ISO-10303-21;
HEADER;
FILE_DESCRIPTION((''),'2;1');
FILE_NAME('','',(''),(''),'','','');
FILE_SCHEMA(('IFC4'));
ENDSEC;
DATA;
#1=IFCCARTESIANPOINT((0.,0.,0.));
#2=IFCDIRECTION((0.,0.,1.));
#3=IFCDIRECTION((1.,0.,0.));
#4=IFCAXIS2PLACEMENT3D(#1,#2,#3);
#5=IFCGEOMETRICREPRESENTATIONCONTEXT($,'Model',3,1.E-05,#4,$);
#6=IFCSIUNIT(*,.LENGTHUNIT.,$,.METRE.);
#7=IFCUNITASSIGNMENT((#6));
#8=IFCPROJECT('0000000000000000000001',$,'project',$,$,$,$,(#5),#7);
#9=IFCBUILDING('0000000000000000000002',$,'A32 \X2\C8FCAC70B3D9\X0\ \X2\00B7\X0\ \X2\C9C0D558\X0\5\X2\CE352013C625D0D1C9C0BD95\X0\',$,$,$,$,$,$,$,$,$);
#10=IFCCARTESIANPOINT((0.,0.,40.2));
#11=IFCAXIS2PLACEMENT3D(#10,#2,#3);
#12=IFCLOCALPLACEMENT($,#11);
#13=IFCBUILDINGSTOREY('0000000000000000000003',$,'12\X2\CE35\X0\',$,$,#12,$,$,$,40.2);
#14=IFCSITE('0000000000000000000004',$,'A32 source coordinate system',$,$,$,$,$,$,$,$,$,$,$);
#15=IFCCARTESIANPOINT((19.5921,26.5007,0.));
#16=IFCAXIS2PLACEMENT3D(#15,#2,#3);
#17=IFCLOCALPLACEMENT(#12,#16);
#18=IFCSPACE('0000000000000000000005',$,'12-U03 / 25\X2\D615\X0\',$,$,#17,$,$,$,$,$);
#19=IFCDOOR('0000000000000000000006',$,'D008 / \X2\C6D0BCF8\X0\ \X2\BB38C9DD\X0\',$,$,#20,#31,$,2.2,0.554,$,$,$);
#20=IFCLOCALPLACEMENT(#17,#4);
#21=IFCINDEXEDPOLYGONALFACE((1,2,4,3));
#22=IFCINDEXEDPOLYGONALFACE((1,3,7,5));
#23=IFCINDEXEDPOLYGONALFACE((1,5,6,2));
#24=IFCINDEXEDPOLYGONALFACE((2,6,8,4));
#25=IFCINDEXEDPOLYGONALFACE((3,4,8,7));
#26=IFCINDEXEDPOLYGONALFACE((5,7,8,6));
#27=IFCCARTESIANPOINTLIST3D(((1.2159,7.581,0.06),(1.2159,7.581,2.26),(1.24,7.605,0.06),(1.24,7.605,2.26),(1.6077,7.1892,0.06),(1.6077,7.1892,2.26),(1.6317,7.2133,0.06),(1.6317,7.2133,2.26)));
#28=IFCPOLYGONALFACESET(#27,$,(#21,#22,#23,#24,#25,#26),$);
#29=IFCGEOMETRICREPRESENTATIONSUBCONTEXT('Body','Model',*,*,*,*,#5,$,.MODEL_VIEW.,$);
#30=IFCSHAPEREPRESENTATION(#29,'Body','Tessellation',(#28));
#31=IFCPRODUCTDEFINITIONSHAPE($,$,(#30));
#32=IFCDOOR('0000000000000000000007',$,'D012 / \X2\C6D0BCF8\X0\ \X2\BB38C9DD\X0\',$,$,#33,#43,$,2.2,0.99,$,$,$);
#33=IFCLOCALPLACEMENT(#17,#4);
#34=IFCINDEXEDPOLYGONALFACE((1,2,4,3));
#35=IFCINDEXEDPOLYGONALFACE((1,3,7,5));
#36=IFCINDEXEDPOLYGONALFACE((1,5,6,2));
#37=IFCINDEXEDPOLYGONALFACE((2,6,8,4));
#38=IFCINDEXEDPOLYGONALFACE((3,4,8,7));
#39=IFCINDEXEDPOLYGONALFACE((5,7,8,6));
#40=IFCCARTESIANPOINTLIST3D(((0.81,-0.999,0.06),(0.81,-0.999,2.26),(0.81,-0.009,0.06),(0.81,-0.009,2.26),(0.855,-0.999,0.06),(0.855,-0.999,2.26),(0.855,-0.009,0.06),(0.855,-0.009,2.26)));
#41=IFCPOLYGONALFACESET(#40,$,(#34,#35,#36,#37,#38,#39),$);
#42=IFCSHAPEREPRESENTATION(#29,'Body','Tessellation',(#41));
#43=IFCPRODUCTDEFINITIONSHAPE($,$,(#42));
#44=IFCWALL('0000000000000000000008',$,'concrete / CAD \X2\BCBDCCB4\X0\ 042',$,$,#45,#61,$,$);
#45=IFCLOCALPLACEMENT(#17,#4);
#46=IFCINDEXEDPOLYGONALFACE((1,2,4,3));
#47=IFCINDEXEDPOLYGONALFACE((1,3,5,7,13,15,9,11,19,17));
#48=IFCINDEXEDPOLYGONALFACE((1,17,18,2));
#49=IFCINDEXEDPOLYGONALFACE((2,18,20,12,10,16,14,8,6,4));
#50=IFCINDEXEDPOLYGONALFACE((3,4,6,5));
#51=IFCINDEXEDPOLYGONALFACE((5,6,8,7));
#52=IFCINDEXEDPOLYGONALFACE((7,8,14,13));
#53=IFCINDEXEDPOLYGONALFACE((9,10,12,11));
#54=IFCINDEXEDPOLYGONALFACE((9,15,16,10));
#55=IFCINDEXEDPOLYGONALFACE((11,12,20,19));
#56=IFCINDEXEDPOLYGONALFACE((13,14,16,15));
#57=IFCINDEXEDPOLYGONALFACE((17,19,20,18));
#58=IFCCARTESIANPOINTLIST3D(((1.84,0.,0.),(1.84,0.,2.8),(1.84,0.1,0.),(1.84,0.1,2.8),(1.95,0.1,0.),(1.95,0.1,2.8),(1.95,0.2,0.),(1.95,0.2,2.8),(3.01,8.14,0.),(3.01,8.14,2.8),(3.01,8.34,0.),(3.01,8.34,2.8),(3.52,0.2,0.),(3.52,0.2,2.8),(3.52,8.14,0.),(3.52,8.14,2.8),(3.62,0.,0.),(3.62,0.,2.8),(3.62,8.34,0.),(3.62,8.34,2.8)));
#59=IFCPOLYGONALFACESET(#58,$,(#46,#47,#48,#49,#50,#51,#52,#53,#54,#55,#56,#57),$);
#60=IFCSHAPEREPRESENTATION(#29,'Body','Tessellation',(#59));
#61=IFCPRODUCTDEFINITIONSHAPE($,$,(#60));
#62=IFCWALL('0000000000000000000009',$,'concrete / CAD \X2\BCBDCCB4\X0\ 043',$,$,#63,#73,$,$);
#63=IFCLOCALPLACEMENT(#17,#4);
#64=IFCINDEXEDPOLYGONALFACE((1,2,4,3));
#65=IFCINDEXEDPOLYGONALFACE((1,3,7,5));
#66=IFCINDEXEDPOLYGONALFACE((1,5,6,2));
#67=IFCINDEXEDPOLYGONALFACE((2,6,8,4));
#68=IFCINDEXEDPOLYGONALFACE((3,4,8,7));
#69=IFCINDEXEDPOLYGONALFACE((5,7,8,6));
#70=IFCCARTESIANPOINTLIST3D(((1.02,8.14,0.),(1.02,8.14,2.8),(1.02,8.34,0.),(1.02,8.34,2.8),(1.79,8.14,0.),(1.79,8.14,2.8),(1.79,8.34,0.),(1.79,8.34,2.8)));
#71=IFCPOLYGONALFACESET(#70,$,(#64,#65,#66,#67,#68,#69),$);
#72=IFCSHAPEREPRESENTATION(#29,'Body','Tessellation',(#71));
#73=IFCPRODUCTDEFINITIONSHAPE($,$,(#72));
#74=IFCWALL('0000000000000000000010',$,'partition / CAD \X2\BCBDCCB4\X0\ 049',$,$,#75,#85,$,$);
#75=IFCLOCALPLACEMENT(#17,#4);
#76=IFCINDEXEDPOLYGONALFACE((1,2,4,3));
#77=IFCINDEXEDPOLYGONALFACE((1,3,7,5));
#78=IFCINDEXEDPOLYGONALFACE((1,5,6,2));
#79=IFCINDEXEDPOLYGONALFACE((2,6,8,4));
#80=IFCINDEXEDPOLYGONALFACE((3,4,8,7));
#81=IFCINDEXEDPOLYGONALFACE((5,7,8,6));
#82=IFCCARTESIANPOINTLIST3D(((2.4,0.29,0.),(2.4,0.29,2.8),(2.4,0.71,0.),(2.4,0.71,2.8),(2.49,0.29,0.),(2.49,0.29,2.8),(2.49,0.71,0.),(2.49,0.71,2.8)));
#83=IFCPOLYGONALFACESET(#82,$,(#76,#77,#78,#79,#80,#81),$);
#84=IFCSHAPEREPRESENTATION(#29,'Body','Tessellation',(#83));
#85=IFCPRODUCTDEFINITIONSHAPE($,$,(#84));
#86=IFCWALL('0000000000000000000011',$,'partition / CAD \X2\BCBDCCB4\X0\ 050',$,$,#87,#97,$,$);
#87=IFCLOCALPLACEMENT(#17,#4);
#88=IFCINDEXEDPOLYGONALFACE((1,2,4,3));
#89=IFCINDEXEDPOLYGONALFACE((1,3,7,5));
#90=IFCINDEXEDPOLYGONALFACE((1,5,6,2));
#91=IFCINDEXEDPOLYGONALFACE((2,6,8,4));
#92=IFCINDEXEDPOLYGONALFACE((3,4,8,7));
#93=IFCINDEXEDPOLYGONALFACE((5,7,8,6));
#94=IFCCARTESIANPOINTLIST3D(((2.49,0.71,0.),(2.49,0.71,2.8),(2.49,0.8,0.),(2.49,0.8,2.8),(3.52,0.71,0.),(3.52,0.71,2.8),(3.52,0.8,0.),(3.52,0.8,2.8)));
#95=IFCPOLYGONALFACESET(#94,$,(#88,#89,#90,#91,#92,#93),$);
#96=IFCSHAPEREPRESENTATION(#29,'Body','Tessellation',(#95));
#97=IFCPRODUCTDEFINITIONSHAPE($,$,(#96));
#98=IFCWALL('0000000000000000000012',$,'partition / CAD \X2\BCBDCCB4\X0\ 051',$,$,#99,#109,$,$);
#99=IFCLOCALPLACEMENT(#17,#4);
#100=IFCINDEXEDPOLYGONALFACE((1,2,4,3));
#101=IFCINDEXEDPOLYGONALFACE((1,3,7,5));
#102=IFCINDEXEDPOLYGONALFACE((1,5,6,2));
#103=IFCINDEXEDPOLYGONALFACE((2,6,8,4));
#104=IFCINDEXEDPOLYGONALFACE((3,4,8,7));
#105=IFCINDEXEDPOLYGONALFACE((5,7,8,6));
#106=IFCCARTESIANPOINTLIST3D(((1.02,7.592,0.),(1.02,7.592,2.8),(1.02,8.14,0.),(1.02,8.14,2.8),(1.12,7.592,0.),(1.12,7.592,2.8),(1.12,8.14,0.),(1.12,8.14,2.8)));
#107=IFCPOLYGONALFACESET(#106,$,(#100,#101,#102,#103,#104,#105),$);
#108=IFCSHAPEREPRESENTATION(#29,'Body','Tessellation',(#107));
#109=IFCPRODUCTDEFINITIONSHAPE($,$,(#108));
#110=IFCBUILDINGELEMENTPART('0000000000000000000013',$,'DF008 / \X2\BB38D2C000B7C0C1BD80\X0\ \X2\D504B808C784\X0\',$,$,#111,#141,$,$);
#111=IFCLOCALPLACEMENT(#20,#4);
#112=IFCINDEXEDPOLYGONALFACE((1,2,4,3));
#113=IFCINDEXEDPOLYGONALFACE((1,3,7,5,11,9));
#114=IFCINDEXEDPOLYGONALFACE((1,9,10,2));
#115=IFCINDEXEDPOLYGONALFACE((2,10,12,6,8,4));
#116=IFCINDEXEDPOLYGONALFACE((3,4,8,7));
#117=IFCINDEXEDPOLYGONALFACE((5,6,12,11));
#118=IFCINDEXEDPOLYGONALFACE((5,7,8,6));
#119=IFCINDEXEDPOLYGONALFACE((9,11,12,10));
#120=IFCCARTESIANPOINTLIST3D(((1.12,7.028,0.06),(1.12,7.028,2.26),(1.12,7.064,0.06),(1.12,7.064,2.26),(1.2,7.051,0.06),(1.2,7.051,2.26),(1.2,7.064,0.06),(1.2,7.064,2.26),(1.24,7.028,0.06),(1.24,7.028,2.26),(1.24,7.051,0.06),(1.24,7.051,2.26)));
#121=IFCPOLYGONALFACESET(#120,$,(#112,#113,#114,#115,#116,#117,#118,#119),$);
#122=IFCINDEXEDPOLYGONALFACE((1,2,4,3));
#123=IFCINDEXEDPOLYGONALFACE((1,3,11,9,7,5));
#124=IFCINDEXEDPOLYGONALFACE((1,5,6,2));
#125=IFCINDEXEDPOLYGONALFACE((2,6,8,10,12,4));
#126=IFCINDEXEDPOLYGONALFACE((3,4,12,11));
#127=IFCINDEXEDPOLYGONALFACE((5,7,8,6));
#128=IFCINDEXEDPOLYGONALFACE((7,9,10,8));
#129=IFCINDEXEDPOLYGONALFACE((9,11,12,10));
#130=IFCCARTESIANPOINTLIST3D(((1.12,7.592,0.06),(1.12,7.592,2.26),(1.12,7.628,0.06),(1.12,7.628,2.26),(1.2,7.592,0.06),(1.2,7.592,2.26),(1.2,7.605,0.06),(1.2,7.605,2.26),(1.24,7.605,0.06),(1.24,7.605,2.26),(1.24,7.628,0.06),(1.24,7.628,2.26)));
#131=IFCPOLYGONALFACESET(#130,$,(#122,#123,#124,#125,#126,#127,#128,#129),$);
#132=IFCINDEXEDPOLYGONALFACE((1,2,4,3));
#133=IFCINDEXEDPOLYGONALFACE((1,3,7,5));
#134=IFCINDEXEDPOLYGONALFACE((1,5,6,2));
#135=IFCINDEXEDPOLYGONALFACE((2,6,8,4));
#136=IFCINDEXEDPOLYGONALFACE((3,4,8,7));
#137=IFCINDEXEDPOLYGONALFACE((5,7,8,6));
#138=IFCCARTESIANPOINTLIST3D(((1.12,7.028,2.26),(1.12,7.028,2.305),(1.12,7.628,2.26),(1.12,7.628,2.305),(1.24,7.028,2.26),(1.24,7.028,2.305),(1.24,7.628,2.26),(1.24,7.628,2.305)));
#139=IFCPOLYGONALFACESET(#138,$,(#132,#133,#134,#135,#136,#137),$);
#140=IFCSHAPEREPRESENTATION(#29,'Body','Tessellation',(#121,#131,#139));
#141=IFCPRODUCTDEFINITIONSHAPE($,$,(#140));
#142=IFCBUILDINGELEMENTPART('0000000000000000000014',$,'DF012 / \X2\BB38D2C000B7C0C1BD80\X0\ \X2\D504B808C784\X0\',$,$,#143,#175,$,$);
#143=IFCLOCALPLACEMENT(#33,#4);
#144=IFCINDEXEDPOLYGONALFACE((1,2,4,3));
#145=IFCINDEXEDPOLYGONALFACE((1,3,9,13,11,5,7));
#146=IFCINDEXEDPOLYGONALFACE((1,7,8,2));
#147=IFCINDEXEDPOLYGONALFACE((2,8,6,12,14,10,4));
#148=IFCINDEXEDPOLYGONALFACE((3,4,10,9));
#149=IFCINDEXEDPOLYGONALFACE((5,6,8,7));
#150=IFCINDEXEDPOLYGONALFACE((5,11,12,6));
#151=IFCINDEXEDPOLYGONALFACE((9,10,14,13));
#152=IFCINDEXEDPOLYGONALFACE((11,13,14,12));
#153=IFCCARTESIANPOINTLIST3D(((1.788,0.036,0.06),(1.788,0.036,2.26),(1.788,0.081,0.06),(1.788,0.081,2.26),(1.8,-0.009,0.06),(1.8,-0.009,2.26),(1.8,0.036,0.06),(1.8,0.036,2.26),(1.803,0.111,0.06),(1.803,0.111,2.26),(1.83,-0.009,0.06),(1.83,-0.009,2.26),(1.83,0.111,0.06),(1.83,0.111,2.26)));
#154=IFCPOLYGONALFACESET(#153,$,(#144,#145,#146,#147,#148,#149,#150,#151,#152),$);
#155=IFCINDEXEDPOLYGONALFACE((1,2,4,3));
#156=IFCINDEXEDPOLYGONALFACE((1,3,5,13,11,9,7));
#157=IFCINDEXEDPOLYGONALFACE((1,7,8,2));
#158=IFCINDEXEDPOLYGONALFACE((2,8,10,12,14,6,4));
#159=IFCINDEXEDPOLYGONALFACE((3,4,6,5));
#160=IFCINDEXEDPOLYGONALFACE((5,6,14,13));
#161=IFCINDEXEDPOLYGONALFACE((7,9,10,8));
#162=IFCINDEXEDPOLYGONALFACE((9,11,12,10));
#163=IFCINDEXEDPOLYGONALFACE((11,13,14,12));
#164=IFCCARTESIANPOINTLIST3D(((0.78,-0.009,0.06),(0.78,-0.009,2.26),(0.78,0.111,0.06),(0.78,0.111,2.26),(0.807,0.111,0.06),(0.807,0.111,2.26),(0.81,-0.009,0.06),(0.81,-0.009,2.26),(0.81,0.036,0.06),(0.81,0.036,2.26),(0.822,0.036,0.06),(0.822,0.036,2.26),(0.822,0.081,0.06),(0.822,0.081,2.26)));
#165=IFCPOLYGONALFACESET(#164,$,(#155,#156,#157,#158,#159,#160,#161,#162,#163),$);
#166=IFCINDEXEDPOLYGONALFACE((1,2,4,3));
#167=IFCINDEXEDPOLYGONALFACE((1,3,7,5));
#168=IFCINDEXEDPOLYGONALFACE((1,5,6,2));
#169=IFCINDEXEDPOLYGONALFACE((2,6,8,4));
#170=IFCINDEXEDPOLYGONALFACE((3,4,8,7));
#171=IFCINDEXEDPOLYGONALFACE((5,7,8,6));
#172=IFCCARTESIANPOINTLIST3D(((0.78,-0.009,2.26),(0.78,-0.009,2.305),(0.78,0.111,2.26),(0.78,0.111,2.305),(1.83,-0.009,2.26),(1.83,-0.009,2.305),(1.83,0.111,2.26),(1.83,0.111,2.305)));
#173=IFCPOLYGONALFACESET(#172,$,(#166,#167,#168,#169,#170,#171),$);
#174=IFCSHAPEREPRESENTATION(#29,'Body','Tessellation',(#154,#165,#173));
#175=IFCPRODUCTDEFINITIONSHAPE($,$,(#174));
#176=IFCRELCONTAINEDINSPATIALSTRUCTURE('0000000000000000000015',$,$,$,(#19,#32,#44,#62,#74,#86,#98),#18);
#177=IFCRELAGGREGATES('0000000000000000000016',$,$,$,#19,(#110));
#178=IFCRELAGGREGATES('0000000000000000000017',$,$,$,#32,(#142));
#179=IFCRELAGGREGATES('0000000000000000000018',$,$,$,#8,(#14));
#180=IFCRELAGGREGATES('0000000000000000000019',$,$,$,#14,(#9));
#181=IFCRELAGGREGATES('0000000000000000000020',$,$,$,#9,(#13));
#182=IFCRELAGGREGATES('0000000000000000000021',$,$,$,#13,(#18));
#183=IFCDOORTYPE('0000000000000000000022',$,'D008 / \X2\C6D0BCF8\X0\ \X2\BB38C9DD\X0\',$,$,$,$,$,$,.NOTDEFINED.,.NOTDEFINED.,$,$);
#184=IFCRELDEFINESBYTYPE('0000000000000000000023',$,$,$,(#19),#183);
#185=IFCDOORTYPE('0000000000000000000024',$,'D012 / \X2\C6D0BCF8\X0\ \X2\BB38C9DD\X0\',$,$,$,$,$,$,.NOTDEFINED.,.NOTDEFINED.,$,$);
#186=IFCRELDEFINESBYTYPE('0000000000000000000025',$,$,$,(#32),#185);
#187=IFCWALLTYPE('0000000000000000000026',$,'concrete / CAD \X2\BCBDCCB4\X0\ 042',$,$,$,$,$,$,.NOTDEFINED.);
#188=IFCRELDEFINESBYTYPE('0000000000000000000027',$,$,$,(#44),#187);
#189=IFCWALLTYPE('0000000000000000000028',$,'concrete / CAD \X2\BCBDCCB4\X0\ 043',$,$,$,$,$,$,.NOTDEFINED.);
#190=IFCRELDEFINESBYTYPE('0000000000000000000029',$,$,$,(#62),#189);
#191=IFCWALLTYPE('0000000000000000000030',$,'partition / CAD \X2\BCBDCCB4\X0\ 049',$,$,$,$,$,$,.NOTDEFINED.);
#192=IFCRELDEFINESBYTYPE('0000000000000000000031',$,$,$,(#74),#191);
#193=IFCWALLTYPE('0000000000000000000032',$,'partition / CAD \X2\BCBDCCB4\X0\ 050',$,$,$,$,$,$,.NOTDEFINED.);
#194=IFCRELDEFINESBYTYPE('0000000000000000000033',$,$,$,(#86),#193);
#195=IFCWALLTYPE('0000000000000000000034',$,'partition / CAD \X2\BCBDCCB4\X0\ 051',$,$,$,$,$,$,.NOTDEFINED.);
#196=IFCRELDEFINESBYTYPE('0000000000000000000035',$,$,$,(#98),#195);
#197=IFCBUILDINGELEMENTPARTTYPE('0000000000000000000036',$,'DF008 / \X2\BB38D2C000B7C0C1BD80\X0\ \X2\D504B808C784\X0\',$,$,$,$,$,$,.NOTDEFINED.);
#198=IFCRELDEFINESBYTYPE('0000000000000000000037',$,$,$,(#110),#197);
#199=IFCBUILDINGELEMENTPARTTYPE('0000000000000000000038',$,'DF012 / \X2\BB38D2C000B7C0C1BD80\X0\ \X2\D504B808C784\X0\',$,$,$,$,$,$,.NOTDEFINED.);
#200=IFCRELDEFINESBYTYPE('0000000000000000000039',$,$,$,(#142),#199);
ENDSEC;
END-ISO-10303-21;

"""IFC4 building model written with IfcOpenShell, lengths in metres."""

from ifc_helpers import new_model, si_unit, frame, origin, origin_with_axes, place, context, subcontext, project, spatial, polyline, outline, extrude, source, transform, mapped, type_object, type_shapes, element, aggregate, save


model = new_model("IFC4")

# Units and contexts
model_context = context("Model", 3, precision=1e-05, world=origin_with_axes())
body_context = subcontext(model_context, "Body", "Model", "MODEL_VIEW")
ifc_project = project(units=[si_unit("LENGTHUNIT", "METRE")], contexts=[model_context])

# Site, building, storey, space
storey_placement = place(None, frame((0.0, 0.0, 40.2), z_axis=(0.0, 0.0, 1.0), x_axis=(1.0, 0.0, 0.0)))
space_placement = place(storey_placement, frame((19.5921, 26.5007, 0.0), z_axis=(0.0, 0.0, 1.0), x_axis=(1.0, 0.0, 0.0)))
site = spatial("IfcSite", under=ifc_project, Name="A32 source coordinate system")
building = spatial("IfcBuilding", under=site, Name="A32 주거동 · 지하5층–옥탑지붕")
storey = spatial("IfcBuildingStorey", under=building, at=storey_placement, Name="12층", Elevation=40.2)
space = spatial("IfcSpace", under=storey, at=space_placement, Name="12-U03 / 25형")

# Doors
door_type_1 = type_object("IfcDoorType", Name="D008 / 원본 문짝", OperationType="NOTDEFINED", PredefinedType="NOTDEFINED")
shared_shape_1 = source(origin(), body_context, "Body", "SweptSolid", [
    extrude(outline(polyline([(1.24, 7.605), (1.6317, 7.2133), (1.6077, 7.1892), (1.2159, 7.581), (1.24, 7.605)])), frame((0.0, 0.0, 0.06)), (0.0, 0.0, 1.0), 2.2),
])
type_shapes(door_type_1, [shared_shape_1])
door_1_placement = place(space_placement, origin_with_axes())
door_1 = element("IfcDoor", 1, at=door_1_placement, inside=space, type_object=door_type_1, Name="D008 / 원본 문짝", OverallHeight=2.2, OverallWidth=0.554, context=body_context, shape_type="MappedRepresentation", body=[
    mapped(shared_shape_1, transform((0.0, 0.0, 0.0), scale=1.0)),
])
door_type_2 = type_object("IfcDoorType", Name="D012 / 원본 문짝", OperationType="NOTDEFINED", PredefinedType="NOTDEFINED")
shared_shape_2 = source(origin(), body_context, "Body", "SweptSolid", [
    extrude(outline(polyline([(0.855, -0.999), (0.81, -0.999), (0.81, -0.009), (0.855, -0.009), (0.855, -0.999)])), frame((0.0, 0.0, 0.06)), (0.0, 0.0, 1.0), 2.2),
])
type_shapes(door_type_2, [shared_shape_2])
door_2_placement = place(space_placement, origin_with_axes())
door_2 = element("IfcDoor", 2, at=door_2_placement, inside=space, type_object=door_type_2, Name="D012 / 원본 문짝", OverallHeight=2.2, OverallWidth=0.99, context=body_context, shape_type="MappedRepresentation", body=[
    mapped(shared_shape_2, transform((0.0, 0.0, 0.0), scale=1.0)),
])

# Walls
wall_type_1 = type_object("IfcWallType", Name="concrete / CAD 벽체 042", PredefinedType="NOTDEFINED")
shared_shape_3 = source(origin(), body_context, "Body", "SweptSolid", [
    extrude(outline(polyline([(3.01, 8.34), (3.97, 8.34), (3.97, 8.34), (3.62, 8.34), (3.62, 0.0), (1.84, 0.0), (1.84, 0.1), (1.95, 0.1), (1.95, 0.2), (3.52, 0.2), (3.52, 8.14), (3.01, 8.14), (3.01, 8.34)])), origin(), (0.0, 0.0, 1.0), 2.8),
])
type_shapes(wall_type_1, [shared_shape_3])
wall_1_placement = place(space_placement, origin_with_axes())
element("IfcWall", 3, at=wall_1_placement, inside=space, type_object=wall_type_1, Name="concrete / CAD 벽체 042", context=body_context, shape_type="MappedRepresentation", body=[
    mapped(shared_shape_3, transform((0.0, 0.0, 0.0), scale=1.0)),
])
wall_type_2 = type_object("IfcWallType", Name="concrete / CAD 벽체 043", PredefinedType="NOTDEFINED")
shared_shape_4 = source(origin(), body_context, "Body", "SweptSolid", [
    extrude(outline(polyline([(1.79, 8.14), (1.02, 8.14), (1.02, 8.34), (1.79, 8.34), (1.79, 8.14)])), origin(), (0.0, 0.0, 1.0), 2.8),
])
type_shapes(wall_type_2, [shared_shape_4])
wall_2_placement = place(space_placement, origin_with_axes())
element("IfcWall", 4, at=wall_2_placement, inside=space, type_object=wall_type_2, Name="concrete / CAD 벽체 043", context=body_context, shape_type="MappedRepresentation", body=[
    mapped(shared_shape_4, transform((0.0, 0.0, 0.0), scale=1.0)),
])
wall_type_3 = type_object("IfcWallType", Name="partition / CAD 벽체 049", PredefinedType="NOTDEFINED")
shared_shape_5 = source(origin(), body_context, "Body", "SweptSolid", [
    extrude(outline(polyline([(2.49, 0.29), (2.4, 0.29), (2.4, 0.71), (2.49, 0.71), (2.49, 0.29)])), origin(), (0.0, 0.0, 1.0), 2.8),
])
type_shapes(wall_type_3, [shared_shape_5])
wall_3_placement = place(space_placement, origin_with_axes())
element("IfcWall", 5, at=wall_3_placement, inside=space, type_object=wall_type_3, Name="partition / CAD 벽체 049", context=body_context, shape_type="MappedRepresentation", body=[
    mapped(shared_shape_5, transform((0.0, 0.0, 0.0), scale=1.0)),
])
wall_type_4 = type_object("IfcWallType", Name="partition / CAD 벽체 050", PredefinedType="NOTDEFINED")
shared_shape_6 = source(origin(), body_context, "Body", "SweptSolid", [
    extrude(outline(polyline([(2.49, 0.71), (2.49, 0.8), (3.52, 0.8), (3.52, 0.71), (2.49, 0.71)])), origin(), (0.0, 0.0, 1.0), 2.8),
])
type_shapes(wall_type_4, [shared_shape_6])
wall_4_placement = place(space_placement, origin_with_axes())
element("IfcWall", 6, at=wall_4_placement, inside=space, type_object=wall_type_4, Name="partition / CAD 벽체 050", context=body_context, shape_type="MappedRepresentation", body=[
    mapped(shared_shape_6, transform((0.0, 0.0, 0.0), scale=1.0)),
])
wall_type_5 = type_object("IfcWallType", Name="partition / CAD 벽체 051", PredefinedType="NOTDEFINED")
shared_shape_7 = source(origin(), body_context, "Body", "SweptSolid", [
    extrude(outline(polyline([(1.02, 8.14), (1.12, 8.14), (1.12, 7.592), (1.02, 7.592), (1.02, 8.14)])), origin(), (0.0, 0.0, 1.0), 2.8),
])
type_shapes(wall_type_5, [shared_shape_7])
wall_5_placement = place(space_placement, origin_with_axes())
element("IfcWall", 7, at=wall_5_placement, inside=space, type_object=wall_type_5, Name="partition / CAD 벽체 051", context=body_context, shape_type="MappedRepresentation", body=[
    mapped(shared_shape_7, transform((0.0, 0.0, 0.0), scale=1.0)),
])

# Building element parts
building_element_part_type_1 = type_object("IfcBuildingElementPartType", Name="DF008 / 문틀·상부 프레임", PredefinedType="NOTDEFINED")
shared_shape_8 = source(origin(), body_context, "Body", "SweptSolid", [
    extrude(outline(polyline([(1.12, 7.064), (1.2, 7.064), (1.2, 7.051), (1.24, 7.051), (1.24, 7.028), (1.12, 7.028), (1.12, 7.064)])), frame((0.0, 0.0, 0.06)), (0.0, 0.0, 1.0), 2.2),
    extrude(outline(polyline([(1.24, 7.628), (1.24, 7.605), (1.2, 7.605), (1.2, 7.592), (1.12, 7.592), (1.12, 7.628), (1.24, 7.628)])), frame((0.0, 0.0, 0.06)), (0.0, 0.0, 1.0), 2.2),
    extrude(outline(polyline([(1.12, 7.028), (1.12, 7.628), (1.24, 7.628), (1.24, 7.028), (1.12, 7.028)])), frame((0.0, 0.0, 2.26)), (0.0, 0.0, 1.0), 0.045),
])
type_shapes(building_element_part_type_1, [shared_shape_8])
building_element_part_1_placement = place(door_1_placement, origin_with_axes())
building_element_part_1 = element("IfcBuildingElementPart", 8, at=building_element_part_1_placement, type_object=building_element_part_type_1, Name="DF008 / 문틀·상부 프레임", context=body_context, shape_type="MappedRepresentation", body=[
    mapped(shared_shape_8, transform((0.0, 0.0, 0.0), scale=1.0)),
])
aggregate(door_1, [building_element_part_1])
building_element_part_type_2 = type_object("IfcBuildingElementPartType", Name="DF012 / 문틀·상부 프레임", PredefinedType="NOTDEFINED")
shared_shape_9 = source(origin(), body_context, "Body", "SweptSolid", [
    extrude(outline(polyline([(1.8, -0.009), (1.8, 0.036), (1.788, 0.036), (1.788, 0.081), (1.803, 0.111), (1.83, 0.111), (1.83, -0.009), (1.8, -0.009)])), frame((0.0, 0.0, 0.06)), (0.0, 0.0, 1.0), 2.2),
    extrude(outline(polyline([(0.78, 0.111), (0.807, 0.111), (0.822, 0.081), (0.822, 0.036), (0.81, 0.036), (0.81, -0.009), (0.78, -0.009), (0.78, 0.111)])), frame((0.0, 0.0, 0.06)), (0.0, 0.0, 1.0), 2.2),
    extrude(outline(polyline([(0.78, -0.009), (0.78, 0.111), (1.83, 0.111), (1.83, -0.009), (0.78, -0.009)])), frame((0.0, 0.0, 2.26)), (0.0, 0.0, 1.0), 0.045),
])
type_shapes(building_element_part_type_2, [shared_shape_9])
building_element_part_2_placement = place(door_2_placement, origin_with_axes())
building_element_part_2 = element("IfcBuildingElementPart", 9, at=building_element_part_2_placement, type_object=building_element_part_type_2, Name="DF012 / 문틀·상부 프레임", context=body_context, shape_type="MappedRepresentation", body=[
    mapped(shared_shape_9, transform((0.0, 0.0, 0.0), scale=1.0)),
])
aggregate(door_2, [building_element_part_2])

save(model, "model.ifc")
